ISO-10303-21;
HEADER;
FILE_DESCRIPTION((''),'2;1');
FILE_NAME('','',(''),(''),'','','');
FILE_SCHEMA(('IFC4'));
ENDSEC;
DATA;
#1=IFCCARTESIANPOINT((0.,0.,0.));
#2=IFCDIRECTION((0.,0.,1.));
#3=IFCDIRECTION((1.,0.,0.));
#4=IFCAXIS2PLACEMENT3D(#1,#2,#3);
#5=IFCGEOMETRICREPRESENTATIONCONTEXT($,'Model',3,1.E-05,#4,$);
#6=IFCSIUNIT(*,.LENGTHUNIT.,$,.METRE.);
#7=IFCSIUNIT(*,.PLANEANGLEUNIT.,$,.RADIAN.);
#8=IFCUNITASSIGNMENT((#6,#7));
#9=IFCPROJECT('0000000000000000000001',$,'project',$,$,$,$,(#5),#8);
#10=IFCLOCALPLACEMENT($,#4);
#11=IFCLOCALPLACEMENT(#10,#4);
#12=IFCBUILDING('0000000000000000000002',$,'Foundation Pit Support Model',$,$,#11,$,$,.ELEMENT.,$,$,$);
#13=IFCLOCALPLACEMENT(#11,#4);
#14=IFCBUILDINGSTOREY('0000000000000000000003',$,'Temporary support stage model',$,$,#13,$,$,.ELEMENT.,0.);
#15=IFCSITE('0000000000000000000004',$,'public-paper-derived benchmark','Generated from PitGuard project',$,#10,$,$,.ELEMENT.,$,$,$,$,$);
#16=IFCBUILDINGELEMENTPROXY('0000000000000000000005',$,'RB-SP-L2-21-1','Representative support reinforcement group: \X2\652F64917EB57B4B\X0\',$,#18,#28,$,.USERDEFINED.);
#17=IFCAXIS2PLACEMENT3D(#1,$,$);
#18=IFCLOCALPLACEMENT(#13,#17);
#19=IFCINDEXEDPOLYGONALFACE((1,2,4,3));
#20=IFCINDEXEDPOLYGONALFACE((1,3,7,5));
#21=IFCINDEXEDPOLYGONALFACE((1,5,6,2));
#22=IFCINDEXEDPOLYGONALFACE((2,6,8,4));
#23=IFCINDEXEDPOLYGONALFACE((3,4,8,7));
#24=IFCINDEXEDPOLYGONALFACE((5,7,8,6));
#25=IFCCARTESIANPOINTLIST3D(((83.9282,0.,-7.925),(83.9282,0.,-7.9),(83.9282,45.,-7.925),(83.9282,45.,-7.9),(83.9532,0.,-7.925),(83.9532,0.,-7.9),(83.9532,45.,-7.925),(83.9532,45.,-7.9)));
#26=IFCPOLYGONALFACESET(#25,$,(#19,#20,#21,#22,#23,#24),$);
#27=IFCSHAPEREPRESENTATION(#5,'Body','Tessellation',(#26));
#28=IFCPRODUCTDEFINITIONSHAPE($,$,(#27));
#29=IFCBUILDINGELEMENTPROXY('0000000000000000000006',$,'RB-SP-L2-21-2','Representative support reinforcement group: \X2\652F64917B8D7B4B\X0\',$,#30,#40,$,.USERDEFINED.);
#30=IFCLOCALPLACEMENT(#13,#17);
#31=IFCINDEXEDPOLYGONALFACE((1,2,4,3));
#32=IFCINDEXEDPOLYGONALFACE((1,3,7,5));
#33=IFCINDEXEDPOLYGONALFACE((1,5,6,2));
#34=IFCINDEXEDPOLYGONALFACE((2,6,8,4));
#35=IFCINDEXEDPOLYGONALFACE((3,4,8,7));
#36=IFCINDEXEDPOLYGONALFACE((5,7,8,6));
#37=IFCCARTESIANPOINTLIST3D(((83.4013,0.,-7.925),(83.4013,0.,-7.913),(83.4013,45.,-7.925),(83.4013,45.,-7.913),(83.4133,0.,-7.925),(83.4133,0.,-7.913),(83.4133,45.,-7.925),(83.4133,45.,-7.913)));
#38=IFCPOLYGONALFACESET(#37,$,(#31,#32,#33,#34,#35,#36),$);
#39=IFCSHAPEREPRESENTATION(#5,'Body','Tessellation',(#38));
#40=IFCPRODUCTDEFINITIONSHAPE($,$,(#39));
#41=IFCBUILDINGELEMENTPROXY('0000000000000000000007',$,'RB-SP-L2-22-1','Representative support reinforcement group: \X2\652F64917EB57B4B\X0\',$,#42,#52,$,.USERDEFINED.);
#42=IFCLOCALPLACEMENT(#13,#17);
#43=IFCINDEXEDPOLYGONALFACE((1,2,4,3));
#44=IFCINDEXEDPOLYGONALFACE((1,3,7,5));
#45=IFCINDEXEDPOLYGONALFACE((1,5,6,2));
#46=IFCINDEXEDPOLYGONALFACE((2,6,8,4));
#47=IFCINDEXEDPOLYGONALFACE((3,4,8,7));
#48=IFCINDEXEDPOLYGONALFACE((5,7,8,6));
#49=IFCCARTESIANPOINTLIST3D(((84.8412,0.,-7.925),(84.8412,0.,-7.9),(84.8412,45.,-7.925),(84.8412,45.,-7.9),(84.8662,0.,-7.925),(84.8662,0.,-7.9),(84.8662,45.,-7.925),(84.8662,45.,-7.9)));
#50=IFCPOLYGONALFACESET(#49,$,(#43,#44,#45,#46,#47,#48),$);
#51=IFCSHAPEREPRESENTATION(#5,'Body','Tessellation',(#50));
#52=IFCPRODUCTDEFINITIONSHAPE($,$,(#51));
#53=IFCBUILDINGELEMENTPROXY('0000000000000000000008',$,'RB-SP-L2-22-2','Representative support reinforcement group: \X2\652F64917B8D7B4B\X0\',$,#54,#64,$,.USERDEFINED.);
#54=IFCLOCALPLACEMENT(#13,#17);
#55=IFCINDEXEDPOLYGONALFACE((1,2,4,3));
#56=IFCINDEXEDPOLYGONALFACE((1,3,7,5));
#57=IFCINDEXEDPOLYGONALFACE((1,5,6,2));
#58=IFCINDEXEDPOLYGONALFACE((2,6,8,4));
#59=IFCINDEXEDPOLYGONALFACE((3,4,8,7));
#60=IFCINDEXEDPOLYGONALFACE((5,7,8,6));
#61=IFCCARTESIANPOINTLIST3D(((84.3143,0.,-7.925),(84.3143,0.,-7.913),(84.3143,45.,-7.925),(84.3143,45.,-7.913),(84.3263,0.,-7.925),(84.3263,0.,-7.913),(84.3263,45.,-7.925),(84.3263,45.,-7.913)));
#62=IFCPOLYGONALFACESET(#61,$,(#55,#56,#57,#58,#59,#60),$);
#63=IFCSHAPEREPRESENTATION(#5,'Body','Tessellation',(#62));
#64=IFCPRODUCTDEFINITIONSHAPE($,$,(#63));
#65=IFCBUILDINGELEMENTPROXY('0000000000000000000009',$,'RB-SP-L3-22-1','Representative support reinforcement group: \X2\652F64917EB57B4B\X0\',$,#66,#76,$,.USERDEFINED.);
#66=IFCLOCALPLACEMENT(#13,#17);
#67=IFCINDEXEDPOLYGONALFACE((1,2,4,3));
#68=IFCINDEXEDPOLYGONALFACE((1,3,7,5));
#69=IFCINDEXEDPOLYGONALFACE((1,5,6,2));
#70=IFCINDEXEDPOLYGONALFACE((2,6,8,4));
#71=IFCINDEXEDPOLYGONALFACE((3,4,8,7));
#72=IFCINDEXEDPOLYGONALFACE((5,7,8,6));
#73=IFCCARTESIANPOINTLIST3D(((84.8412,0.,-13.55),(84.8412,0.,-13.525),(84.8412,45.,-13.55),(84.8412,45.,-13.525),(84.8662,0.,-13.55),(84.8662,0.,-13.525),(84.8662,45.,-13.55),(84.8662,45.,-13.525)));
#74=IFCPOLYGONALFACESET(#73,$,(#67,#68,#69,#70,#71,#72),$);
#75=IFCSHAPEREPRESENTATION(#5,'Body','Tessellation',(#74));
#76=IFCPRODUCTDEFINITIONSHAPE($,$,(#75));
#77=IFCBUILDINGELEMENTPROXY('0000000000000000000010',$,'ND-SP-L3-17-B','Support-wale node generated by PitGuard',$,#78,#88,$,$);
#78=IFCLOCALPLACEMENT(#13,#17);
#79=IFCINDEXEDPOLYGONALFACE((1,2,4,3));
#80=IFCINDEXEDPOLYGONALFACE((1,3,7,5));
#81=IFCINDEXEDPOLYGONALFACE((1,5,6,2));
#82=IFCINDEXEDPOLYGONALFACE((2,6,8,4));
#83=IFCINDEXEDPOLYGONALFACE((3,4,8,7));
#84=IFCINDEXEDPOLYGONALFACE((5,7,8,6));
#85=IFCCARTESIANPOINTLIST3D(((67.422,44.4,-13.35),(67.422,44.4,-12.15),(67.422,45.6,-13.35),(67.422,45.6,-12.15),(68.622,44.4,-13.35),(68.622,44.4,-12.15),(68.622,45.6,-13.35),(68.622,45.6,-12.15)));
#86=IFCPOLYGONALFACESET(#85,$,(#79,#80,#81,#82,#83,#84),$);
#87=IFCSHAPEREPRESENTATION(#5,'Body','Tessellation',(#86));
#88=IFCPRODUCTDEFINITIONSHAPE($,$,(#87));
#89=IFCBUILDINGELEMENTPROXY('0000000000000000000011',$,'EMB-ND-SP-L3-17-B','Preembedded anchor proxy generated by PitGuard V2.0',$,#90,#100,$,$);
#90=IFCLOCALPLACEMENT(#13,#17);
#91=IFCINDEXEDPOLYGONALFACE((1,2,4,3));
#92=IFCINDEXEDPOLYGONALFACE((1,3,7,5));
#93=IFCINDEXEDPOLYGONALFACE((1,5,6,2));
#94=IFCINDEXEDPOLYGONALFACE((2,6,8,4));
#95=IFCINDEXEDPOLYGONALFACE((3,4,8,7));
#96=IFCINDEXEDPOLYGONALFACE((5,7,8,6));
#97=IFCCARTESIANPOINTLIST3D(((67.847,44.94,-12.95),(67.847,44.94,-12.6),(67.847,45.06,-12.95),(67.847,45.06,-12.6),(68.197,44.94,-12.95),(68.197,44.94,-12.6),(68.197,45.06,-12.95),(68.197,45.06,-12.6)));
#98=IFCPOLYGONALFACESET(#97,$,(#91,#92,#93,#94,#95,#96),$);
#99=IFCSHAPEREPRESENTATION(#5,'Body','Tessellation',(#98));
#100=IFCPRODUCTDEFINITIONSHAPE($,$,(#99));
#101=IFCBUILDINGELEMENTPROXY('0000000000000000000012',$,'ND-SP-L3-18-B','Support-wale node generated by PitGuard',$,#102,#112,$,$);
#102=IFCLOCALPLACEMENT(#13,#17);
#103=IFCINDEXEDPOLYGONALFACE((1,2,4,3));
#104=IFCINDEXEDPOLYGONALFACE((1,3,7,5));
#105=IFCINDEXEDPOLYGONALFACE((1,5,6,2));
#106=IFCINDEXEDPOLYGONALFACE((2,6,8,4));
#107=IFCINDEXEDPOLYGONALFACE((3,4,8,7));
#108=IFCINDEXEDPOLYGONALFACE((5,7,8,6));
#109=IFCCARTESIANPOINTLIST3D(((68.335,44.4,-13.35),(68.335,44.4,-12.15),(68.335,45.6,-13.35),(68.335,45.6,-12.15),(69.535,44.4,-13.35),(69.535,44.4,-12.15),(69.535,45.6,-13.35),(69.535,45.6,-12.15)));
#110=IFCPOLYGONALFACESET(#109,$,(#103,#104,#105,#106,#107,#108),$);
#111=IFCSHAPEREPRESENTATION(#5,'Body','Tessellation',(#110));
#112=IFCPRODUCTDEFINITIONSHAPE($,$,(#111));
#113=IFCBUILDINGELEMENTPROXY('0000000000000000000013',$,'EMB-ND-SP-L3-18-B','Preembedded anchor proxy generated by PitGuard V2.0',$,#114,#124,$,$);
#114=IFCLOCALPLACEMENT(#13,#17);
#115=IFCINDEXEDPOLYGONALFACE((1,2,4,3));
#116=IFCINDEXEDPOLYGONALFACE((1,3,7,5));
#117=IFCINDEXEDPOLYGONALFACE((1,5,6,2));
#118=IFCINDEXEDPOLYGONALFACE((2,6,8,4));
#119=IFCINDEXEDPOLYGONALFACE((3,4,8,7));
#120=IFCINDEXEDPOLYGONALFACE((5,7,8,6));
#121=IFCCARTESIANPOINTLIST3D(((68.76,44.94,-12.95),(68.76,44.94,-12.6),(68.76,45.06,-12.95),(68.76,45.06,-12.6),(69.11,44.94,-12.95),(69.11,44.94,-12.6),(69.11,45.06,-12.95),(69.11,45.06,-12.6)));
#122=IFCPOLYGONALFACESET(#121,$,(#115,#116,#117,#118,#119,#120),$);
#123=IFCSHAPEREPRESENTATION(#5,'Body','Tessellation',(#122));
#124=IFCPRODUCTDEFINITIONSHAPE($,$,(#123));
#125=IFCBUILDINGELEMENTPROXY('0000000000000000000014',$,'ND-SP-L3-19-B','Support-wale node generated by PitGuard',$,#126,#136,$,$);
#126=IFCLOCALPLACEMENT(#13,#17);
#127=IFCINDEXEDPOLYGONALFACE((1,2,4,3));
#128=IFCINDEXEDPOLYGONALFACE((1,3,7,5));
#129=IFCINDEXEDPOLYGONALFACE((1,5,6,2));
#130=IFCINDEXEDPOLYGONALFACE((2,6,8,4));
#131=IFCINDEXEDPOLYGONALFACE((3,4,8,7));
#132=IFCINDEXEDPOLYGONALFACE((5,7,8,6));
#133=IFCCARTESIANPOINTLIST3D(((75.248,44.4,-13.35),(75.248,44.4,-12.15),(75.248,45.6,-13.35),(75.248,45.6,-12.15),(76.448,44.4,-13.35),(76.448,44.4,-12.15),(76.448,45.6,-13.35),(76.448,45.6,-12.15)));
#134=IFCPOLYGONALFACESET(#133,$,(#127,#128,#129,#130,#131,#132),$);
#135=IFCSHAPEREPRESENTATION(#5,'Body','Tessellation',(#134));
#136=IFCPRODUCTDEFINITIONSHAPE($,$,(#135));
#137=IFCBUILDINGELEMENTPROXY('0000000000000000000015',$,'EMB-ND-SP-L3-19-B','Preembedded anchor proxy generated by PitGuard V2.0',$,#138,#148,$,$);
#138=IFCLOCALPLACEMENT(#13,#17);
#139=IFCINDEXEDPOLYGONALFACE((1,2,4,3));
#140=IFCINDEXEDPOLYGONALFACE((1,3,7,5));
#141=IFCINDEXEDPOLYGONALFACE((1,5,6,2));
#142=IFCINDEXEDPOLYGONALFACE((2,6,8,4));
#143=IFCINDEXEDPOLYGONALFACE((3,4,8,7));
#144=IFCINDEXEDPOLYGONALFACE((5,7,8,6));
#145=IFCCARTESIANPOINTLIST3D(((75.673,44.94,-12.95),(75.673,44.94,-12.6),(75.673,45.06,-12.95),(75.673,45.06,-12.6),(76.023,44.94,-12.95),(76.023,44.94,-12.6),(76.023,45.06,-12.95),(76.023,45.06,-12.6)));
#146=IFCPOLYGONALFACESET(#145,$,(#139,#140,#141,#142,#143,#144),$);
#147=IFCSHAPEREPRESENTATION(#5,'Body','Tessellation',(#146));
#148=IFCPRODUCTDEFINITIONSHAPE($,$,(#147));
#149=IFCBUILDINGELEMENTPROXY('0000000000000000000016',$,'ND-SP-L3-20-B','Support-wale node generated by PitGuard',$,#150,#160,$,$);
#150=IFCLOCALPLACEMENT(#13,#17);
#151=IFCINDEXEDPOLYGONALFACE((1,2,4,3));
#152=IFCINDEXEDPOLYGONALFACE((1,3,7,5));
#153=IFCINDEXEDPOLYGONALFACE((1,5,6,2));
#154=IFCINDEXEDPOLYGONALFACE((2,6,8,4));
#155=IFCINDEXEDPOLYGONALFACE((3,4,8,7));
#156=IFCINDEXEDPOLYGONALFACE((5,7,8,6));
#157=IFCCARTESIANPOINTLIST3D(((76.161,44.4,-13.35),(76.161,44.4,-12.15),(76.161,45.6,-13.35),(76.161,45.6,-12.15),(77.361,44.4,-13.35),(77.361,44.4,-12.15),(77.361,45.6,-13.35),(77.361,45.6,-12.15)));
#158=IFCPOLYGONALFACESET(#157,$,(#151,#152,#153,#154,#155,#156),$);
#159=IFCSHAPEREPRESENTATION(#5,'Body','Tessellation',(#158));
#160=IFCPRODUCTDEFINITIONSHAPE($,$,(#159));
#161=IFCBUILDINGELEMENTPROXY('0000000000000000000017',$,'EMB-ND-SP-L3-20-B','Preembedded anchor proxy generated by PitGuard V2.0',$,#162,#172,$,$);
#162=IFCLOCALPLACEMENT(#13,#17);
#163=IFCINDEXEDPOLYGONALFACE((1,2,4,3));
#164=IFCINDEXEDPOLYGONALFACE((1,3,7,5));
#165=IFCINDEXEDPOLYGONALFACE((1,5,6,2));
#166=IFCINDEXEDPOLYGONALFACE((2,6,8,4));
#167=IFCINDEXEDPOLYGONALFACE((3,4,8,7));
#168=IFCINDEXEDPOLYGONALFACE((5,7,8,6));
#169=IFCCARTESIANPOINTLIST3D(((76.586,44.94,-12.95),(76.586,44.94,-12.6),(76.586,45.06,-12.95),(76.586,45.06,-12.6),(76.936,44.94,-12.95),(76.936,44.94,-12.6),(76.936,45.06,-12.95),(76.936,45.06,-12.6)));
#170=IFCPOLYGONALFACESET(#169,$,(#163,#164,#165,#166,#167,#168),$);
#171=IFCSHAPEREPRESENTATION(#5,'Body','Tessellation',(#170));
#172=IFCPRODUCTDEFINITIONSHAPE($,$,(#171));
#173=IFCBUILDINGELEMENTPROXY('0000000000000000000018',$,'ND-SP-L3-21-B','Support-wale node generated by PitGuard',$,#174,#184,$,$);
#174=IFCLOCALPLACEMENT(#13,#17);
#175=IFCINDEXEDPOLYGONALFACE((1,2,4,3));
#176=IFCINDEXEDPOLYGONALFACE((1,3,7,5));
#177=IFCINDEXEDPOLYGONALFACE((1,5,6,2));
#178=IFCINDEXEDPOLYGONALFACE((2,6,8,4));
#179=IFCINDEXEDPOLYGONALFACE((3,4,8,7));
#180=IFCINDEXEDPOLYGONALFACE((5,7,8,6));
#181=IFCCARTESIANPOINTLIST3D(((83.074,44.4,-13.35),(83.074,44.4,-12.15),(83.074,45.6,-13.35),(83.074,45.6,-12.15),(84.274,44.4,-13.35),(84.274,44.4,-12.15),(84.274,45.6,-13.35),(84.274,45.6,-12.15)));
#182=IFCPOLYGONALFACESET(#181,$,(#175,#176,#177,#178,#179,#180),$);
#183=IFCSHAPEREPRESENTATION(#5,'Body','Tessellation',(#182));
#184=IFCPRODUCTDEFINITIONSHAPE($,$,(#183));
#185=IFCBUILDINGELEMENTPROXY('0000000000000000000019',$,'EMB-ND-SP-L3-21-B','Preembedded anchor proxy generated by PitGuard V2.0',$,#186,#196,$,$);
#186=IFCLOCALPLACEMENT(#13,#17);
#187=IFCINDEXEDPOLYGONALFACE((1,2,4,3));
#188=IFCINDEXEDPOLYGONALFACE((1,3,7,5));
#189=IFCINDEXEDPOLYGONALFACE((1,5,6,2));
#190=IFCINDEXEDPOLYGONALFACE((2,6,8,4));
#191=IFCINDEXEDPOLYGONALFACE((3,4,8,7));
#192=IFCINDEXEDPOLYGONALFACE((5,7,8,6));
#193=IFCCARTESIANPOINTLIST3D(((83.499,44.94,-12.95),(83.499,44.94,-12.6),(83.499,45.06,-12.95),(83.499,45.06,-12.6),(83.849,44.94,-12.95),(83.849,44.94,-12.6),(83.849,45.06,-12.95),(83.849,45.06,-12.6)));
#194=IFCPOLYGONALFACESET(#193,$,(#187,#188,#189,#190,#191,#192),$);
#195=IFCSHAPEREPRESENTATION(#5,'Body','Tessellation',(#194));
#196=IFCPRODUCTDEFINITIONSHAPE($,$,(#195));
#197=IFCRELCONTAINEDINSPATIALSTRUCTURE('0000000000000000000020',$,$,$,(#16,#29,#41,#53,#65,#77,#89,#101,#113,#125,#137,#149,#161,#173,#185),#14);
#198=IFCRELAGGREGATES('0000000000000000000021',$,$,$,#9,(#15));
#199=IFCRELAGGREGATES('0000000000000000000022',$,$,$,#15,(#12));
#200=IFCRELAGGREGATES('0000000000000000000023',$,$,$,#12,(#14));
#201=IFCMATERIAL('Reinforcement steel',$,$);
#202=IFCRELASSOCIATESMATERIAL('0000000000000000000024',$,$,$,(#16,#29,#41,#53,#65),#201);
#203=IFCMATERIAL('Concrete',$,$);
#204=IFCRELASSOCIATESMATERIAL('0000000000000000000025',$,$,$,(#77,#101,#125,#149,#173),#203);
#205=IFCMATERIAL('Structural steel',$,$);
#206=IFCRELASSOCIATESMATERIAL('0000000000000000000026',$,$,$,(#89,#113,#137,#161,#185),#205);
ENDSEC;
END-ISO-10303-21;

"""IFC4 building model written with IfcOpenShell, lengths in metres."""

from ifc_helpers import new_model, si_unit, frame, origin_with_axes, origin_2d, place, context, project, spatial, rectangle, extrude, material, element, save


model = new_model("IFC4")

# Units and contexts
model_context = context("Model", 3, precision=1e-05, world=origin_with_axes())
ifc_project = project(units=[si_unit("LENGTHUNIT", "METRE"), si_unit("PLANEANGLEUNIT", "RADIAN")], contexts=[model_context])

# Site, building, storey
site_placement = place(None, origin_with_axes())
site = spatial("IfcSite", under=ifc_project, at=site_placement, Name="public-paper-derived benchmark", Description="Generated from PitGuard project", CompositionType="ELEMENT")
building_placement = place(site_placement, origin_with_axes())
building = spatial("IfcBuilding", under=site, at=building_placement, Name="Foundation Pit Support Model", CompositionType="ELEMENT")
storey_placement = place(building_placement, origin_with_axes())
storey = spatial("IfcBuildingStorey", under=building, at=storey_placement, Name="Temporary support stage model", CompositionType="ELEMENT", Elevation=0.0)

# Shared definitions
ifc_material_1 = material(Name="Concrete")

# Shared definitions
ifc_material_2 = material(Name="Structural steel")

# Building element proxies
ifc_material_3 = material(Name="Reinforcement steel")
for number, where, z_axis, x_axis, name in (
    (1, (83.9407, 22.5, -7.925), (0.0, 0.0, 1.0), (0.0, 1.0, 0.0), "RB-SP-L2-21-1"),
):
    element("IfcBuildingElementProxy", number, at=place(storey_placement, frame(where, z_axis=z_axis, x_axis=x_axis)), inside=storey, material=ifc_material_3, Name=name, Description="Representative support reinforcement group: 支撑纵筋", PredefinedType="USERDEFINED", context=model_context, shape_type="SweptSolid", body=[
        extrude(rectangle(XDim=45.0, YDim=0.025, at=origin_2d()), origin_with_axes(), (0.0, 0.0, 1.0), 0.025),
    ])
proxy_1_placement = place(storey_placement, frame((83.4073, 22.5, -7.925), z_axis=(0.0, 0.0, 1.0), x_axis=(0.0, 1.0, 0.0)))
element("IfcBuildingElementProxy", 2, at=proxy_1_placement, inside=storey, material=ifc_material_3, Name="RB-SP-L2-21-2", Description="Representative support reinforcement group: 支撑箍筋", PredefinedType="USERDEFINED", context=model_context, shape_type="SweptSolid", body=[
    extrude(rectangle(XDim=45.0, YDim=0.012, at=origin_2d()), origin_with_axes(), (0.0, 0.0, 1.0), 0.012),
])
proxy_2_placement = place(storey_placement, frame((84.8537, 22.5, -7.925), z_axis=(0.0, 0.0, 1.0), x_axis=(0.0, 1.0, 0.0)))
element("IfcBuildingElementProxy", 3, at=proxy_2_placement, inside=storey, material=ifc_material_3, Name="RB-SP-L2-22-1", Description="Representative support reinforcement group: 支撑纵筋", PredefinedType="USERDEFINED", context=model_context, shape_type="SweptSolid", body=[
    extrude(rectangle(XDim=45.0, YDim=0.025, at=origin_2d()), origin_with_axes(), (0.0, 0.0, 1.0), 0.025),
])
proxy_3_placement = place(storey_placement, frame((84.3203, 22.5, -7.925), z_axis=(0.0, 0.0, 1.0), x_axis=(0.0, 1.0, 0.0)))
element("IfcBuildingElementProxy", 4, at=proxy_3_placement, inside=storey, material=ifc_material_3, Name="RB-SP-L2-22-2", Description="Representative support reinforcement group: 支撑箍筋", PredefinedType="USERDEFINED", context=model_context, shape_type="SweptSolid", body=[
    extrude(rectangle(XDim=45.0, YDim=0.012, at=origin_2d()), origin_with_axes(), (0.0, 0.0, 1.0), 0.012),
])
proxy_4_placement = place(storey_placement, frame((84.8537, 22.5, -13.55), z_axis=(0.0, 0.0, 1.0), x_axis=(0.0, 1.0, 0.0)))
element("IfcBuildingElementProxy", 5, at=proxy_4_placement, inside=storey, material=ifc_material_3, Name="RB-SP-L3-22-1", Description="Representative support reinforcement group: 支撑纵筋", PredefinedType="USERDEFINED", context=model_context, shape_type="SweptSolid", body=[
    extrude(rectangle(XDim=45.0, YDim=0.025, at=origin_2d()), origin_with_axes(), (0.0, 0.0, 1.0), 0.025),
])
proxy_5_placement = place(storey_placement, frame((68.022, 45.0, -13.35), z_axis=(0.0, 0.0, 1.0), x_axis=(1.0, 0.0, 0.0)))
element("IfcBuildingElementProxy", 6, at=proxy_5_placement, inside=storey, material=ifc_material_1, Name="ND-SP-L3-17-B", Description="Support-wale node generated by PitGuard", context=model_context, shape_type="SweptSolid", body=[
    extrude(rectangle(XDim=1.2, YDim=1.2, at=origin_2d()), origin_with_axes(), (0.0, 0.0, 1.0), 1.2),
])
proxy_6_placement = place(storey_placement, frame((68.022, 45.0, -12.95), z_axis=(0.0, 0.0, 1.0), x_axis=(1.0, 0.0, 0.0)))
element("IfcBuildingElementProxy", 7, at=proxy_6_placement, inside=storey, material=ifc_material_2, Name="EMB-ND-SP-L3-17-B", Description="Preembedded anchor proxy generated by PitGuard V2.0", context=model_context, shape_type="SweptSolid", body=[
    extrude(rectangle(XDim=0.35, YDim=0.12, at=origin_2d()), origin_with_axes(), (0.0, 0.0, 1.0), 0.35),
])
proxy_7_placement = place(storey_placement, frame((68.935, 45.0, -13.35), z_axis=(0.0, 0.0, 1.0), x_axis=(1.0, 0.0, 0.0)))
element("IfcBuildingElementProxy", 8, at=proxy_7_placement, inside=storey, material=ifc_material_1, Name="ND-SP-L3-18-B", Description="Support-wale node generated by PitGuard", context=model_context, shape_type="SweptSolid", body=[
    extrude(rectangle(XDim=1.2, YDim=1.2, at=origin_2d()), origin_with_axes(), (0.0, 0.0, 1.0), 1.2),
])
proxy_8_placement = place(storey_placement, frame((68.935, 45.0, -12.95), z_axis=(0.0, 0.0, 1.0), x_axis=(1.0, 0.0, 0.0)))
element("IfcBuildingElementProxy", 9, at=proxy_8_placement, inside=storey, material=ifc_material_2, Name="EMB-ND-SP-L3-18-B", Description="Preembedded anchor proxy generated by PitGuard V2.0", context=model_context, shape_type="SweptSolid", body=[
    extrude(rectangle(XDim=0.35, YDim=0.12, at=origin_2d()), origin_with_axes(), (0.0, 0.0, 1.0), 0.35),
])
proxy_9_placement = place(storey_placement, frame((75.848, 45.0, -13.35), z_axis=(0.0, 0.0, 1.0), x_axis=(1.0, 0.0, 0.0)))
element("IfcBuildingElementProxy", 10, at=proxy_9_placement, inside=storey, material=ifc_material_1, Name="ND-SP-L3-19-B", Description="Support-wale node generated by PitGuard", context=model_context, shape_type="SweptSolid", body=[
    extrude(rectangle(XDim=1.2, YDim=1.2, at=origin_2d()), origin_with_axes(), (0.0, 0.0, 1.0), 1.2),
])
proxy_10_placement = place(storey_placement, frame((75.848, 45.0, -12.95), z_axis=(0.0, 0.0, 1.0), x_axis=(1.0, 0.0, 0.0)))
element("IfcBuildingElementProxy", 11, at=proxy_10_placement, inside=storey, material=ifc_material_2, Name="EMB-ND-SP-L3-19-B", Description="Preembedded anchor proxy generated by PitGuard V2.0", context=model_context, shape_type="SweptSolid", body=[
    extrude(rectangle(XDim=0.35, YDim=0.12, at=origin_2d()), origin_with_axes(), (0.0, 0.0, 1.0), 0.35),
])
proxy_11_placement = place(storey_placement, frame((76.761, 45.0, -13.35), z_axis=(0.0, 0.0, 1.0), x_axis=(1.0, 0.0, 0.0)))
element("IfcBuildingElementProxy", 12, at=proxy_11_placement, inside=storey, material=ifc_material_1, Name="ND-SP-L3-20-B", Description="Support-wale node generated by PitGuard", context=model_context, shape_type="SweptSolid", body=[
    extrude(rectangle(XDim=1.2, YDim=1.2, at=origin_2d()), origin_with_axes(), (0.0, 0.0, 1.0), 1.2),
])
proxy_12_placement = place(storey_placement, frame((76.761, 45.0, -12.95), z_axis=(0.0, 0.0, 1.0), x_axis=(1.0, 0.0, 0.0)))
element("IfcBuildingElementProxy", 13, at=proxy_12_placement, inside=storey, material=ifc_material_2, Name="EMB-ND-SP-L3-20-B", Description="Preembedded anchor proxy generated by PitGuard V2.0", context=model_context, shape_type="SweptSolid", body=[
    extrude(rectangle(XDim=0.35, YDim=0.12, at=origin_2d()), origin_with_axes(), (0.0, 0.0, 1.0), 0.35),
])
proxy_13_placement = place(storey_placement, frame((83.674, 45.0, -13.35), z_axis=(0.0, 0.0, 1.0), x_axis=(1.0, 0.0, 0.0)))
element("IfcBuildingElementProxy", 14, at=proxy_13_placement, inside=storey, material=ifc_material_1, Name="ND-SP-L3-21-B", Description="Support-wale node generated by PitGuard", context=model_context, shape_type="SweptSolid", body=[
    extrude(rectangle(XDim=1.2, YDim=1.2, at=origin_2d()), origin_with_axes(), (0.0, 0.0, 1.0), 1.2),
])
proxy_14_placement = place(storey_placement, frame((83.674, 45.0, -12.95), z_axis=(0.0, 0.0, 1.0), x_axis=(1.0, 0.0, 0.0)))
element("IfcBuildingElementProxy", 15, at=proxy_14_placement, inside=storey, material=ifc_material_2, Name="EMB-ND-SP-L3-21-B", Description="Preembedded anchor proxy generated by PitGuard V2.0", context=model_context, shape_type="SweptSolid", body=[
    extrude(rectangle(XDim=0.35, YDim=0.12, at=origin_2d()), origin_with_axes(), (0.0, 0.0, 1.0), 0.35),
])

save(model, "model.ifc")
